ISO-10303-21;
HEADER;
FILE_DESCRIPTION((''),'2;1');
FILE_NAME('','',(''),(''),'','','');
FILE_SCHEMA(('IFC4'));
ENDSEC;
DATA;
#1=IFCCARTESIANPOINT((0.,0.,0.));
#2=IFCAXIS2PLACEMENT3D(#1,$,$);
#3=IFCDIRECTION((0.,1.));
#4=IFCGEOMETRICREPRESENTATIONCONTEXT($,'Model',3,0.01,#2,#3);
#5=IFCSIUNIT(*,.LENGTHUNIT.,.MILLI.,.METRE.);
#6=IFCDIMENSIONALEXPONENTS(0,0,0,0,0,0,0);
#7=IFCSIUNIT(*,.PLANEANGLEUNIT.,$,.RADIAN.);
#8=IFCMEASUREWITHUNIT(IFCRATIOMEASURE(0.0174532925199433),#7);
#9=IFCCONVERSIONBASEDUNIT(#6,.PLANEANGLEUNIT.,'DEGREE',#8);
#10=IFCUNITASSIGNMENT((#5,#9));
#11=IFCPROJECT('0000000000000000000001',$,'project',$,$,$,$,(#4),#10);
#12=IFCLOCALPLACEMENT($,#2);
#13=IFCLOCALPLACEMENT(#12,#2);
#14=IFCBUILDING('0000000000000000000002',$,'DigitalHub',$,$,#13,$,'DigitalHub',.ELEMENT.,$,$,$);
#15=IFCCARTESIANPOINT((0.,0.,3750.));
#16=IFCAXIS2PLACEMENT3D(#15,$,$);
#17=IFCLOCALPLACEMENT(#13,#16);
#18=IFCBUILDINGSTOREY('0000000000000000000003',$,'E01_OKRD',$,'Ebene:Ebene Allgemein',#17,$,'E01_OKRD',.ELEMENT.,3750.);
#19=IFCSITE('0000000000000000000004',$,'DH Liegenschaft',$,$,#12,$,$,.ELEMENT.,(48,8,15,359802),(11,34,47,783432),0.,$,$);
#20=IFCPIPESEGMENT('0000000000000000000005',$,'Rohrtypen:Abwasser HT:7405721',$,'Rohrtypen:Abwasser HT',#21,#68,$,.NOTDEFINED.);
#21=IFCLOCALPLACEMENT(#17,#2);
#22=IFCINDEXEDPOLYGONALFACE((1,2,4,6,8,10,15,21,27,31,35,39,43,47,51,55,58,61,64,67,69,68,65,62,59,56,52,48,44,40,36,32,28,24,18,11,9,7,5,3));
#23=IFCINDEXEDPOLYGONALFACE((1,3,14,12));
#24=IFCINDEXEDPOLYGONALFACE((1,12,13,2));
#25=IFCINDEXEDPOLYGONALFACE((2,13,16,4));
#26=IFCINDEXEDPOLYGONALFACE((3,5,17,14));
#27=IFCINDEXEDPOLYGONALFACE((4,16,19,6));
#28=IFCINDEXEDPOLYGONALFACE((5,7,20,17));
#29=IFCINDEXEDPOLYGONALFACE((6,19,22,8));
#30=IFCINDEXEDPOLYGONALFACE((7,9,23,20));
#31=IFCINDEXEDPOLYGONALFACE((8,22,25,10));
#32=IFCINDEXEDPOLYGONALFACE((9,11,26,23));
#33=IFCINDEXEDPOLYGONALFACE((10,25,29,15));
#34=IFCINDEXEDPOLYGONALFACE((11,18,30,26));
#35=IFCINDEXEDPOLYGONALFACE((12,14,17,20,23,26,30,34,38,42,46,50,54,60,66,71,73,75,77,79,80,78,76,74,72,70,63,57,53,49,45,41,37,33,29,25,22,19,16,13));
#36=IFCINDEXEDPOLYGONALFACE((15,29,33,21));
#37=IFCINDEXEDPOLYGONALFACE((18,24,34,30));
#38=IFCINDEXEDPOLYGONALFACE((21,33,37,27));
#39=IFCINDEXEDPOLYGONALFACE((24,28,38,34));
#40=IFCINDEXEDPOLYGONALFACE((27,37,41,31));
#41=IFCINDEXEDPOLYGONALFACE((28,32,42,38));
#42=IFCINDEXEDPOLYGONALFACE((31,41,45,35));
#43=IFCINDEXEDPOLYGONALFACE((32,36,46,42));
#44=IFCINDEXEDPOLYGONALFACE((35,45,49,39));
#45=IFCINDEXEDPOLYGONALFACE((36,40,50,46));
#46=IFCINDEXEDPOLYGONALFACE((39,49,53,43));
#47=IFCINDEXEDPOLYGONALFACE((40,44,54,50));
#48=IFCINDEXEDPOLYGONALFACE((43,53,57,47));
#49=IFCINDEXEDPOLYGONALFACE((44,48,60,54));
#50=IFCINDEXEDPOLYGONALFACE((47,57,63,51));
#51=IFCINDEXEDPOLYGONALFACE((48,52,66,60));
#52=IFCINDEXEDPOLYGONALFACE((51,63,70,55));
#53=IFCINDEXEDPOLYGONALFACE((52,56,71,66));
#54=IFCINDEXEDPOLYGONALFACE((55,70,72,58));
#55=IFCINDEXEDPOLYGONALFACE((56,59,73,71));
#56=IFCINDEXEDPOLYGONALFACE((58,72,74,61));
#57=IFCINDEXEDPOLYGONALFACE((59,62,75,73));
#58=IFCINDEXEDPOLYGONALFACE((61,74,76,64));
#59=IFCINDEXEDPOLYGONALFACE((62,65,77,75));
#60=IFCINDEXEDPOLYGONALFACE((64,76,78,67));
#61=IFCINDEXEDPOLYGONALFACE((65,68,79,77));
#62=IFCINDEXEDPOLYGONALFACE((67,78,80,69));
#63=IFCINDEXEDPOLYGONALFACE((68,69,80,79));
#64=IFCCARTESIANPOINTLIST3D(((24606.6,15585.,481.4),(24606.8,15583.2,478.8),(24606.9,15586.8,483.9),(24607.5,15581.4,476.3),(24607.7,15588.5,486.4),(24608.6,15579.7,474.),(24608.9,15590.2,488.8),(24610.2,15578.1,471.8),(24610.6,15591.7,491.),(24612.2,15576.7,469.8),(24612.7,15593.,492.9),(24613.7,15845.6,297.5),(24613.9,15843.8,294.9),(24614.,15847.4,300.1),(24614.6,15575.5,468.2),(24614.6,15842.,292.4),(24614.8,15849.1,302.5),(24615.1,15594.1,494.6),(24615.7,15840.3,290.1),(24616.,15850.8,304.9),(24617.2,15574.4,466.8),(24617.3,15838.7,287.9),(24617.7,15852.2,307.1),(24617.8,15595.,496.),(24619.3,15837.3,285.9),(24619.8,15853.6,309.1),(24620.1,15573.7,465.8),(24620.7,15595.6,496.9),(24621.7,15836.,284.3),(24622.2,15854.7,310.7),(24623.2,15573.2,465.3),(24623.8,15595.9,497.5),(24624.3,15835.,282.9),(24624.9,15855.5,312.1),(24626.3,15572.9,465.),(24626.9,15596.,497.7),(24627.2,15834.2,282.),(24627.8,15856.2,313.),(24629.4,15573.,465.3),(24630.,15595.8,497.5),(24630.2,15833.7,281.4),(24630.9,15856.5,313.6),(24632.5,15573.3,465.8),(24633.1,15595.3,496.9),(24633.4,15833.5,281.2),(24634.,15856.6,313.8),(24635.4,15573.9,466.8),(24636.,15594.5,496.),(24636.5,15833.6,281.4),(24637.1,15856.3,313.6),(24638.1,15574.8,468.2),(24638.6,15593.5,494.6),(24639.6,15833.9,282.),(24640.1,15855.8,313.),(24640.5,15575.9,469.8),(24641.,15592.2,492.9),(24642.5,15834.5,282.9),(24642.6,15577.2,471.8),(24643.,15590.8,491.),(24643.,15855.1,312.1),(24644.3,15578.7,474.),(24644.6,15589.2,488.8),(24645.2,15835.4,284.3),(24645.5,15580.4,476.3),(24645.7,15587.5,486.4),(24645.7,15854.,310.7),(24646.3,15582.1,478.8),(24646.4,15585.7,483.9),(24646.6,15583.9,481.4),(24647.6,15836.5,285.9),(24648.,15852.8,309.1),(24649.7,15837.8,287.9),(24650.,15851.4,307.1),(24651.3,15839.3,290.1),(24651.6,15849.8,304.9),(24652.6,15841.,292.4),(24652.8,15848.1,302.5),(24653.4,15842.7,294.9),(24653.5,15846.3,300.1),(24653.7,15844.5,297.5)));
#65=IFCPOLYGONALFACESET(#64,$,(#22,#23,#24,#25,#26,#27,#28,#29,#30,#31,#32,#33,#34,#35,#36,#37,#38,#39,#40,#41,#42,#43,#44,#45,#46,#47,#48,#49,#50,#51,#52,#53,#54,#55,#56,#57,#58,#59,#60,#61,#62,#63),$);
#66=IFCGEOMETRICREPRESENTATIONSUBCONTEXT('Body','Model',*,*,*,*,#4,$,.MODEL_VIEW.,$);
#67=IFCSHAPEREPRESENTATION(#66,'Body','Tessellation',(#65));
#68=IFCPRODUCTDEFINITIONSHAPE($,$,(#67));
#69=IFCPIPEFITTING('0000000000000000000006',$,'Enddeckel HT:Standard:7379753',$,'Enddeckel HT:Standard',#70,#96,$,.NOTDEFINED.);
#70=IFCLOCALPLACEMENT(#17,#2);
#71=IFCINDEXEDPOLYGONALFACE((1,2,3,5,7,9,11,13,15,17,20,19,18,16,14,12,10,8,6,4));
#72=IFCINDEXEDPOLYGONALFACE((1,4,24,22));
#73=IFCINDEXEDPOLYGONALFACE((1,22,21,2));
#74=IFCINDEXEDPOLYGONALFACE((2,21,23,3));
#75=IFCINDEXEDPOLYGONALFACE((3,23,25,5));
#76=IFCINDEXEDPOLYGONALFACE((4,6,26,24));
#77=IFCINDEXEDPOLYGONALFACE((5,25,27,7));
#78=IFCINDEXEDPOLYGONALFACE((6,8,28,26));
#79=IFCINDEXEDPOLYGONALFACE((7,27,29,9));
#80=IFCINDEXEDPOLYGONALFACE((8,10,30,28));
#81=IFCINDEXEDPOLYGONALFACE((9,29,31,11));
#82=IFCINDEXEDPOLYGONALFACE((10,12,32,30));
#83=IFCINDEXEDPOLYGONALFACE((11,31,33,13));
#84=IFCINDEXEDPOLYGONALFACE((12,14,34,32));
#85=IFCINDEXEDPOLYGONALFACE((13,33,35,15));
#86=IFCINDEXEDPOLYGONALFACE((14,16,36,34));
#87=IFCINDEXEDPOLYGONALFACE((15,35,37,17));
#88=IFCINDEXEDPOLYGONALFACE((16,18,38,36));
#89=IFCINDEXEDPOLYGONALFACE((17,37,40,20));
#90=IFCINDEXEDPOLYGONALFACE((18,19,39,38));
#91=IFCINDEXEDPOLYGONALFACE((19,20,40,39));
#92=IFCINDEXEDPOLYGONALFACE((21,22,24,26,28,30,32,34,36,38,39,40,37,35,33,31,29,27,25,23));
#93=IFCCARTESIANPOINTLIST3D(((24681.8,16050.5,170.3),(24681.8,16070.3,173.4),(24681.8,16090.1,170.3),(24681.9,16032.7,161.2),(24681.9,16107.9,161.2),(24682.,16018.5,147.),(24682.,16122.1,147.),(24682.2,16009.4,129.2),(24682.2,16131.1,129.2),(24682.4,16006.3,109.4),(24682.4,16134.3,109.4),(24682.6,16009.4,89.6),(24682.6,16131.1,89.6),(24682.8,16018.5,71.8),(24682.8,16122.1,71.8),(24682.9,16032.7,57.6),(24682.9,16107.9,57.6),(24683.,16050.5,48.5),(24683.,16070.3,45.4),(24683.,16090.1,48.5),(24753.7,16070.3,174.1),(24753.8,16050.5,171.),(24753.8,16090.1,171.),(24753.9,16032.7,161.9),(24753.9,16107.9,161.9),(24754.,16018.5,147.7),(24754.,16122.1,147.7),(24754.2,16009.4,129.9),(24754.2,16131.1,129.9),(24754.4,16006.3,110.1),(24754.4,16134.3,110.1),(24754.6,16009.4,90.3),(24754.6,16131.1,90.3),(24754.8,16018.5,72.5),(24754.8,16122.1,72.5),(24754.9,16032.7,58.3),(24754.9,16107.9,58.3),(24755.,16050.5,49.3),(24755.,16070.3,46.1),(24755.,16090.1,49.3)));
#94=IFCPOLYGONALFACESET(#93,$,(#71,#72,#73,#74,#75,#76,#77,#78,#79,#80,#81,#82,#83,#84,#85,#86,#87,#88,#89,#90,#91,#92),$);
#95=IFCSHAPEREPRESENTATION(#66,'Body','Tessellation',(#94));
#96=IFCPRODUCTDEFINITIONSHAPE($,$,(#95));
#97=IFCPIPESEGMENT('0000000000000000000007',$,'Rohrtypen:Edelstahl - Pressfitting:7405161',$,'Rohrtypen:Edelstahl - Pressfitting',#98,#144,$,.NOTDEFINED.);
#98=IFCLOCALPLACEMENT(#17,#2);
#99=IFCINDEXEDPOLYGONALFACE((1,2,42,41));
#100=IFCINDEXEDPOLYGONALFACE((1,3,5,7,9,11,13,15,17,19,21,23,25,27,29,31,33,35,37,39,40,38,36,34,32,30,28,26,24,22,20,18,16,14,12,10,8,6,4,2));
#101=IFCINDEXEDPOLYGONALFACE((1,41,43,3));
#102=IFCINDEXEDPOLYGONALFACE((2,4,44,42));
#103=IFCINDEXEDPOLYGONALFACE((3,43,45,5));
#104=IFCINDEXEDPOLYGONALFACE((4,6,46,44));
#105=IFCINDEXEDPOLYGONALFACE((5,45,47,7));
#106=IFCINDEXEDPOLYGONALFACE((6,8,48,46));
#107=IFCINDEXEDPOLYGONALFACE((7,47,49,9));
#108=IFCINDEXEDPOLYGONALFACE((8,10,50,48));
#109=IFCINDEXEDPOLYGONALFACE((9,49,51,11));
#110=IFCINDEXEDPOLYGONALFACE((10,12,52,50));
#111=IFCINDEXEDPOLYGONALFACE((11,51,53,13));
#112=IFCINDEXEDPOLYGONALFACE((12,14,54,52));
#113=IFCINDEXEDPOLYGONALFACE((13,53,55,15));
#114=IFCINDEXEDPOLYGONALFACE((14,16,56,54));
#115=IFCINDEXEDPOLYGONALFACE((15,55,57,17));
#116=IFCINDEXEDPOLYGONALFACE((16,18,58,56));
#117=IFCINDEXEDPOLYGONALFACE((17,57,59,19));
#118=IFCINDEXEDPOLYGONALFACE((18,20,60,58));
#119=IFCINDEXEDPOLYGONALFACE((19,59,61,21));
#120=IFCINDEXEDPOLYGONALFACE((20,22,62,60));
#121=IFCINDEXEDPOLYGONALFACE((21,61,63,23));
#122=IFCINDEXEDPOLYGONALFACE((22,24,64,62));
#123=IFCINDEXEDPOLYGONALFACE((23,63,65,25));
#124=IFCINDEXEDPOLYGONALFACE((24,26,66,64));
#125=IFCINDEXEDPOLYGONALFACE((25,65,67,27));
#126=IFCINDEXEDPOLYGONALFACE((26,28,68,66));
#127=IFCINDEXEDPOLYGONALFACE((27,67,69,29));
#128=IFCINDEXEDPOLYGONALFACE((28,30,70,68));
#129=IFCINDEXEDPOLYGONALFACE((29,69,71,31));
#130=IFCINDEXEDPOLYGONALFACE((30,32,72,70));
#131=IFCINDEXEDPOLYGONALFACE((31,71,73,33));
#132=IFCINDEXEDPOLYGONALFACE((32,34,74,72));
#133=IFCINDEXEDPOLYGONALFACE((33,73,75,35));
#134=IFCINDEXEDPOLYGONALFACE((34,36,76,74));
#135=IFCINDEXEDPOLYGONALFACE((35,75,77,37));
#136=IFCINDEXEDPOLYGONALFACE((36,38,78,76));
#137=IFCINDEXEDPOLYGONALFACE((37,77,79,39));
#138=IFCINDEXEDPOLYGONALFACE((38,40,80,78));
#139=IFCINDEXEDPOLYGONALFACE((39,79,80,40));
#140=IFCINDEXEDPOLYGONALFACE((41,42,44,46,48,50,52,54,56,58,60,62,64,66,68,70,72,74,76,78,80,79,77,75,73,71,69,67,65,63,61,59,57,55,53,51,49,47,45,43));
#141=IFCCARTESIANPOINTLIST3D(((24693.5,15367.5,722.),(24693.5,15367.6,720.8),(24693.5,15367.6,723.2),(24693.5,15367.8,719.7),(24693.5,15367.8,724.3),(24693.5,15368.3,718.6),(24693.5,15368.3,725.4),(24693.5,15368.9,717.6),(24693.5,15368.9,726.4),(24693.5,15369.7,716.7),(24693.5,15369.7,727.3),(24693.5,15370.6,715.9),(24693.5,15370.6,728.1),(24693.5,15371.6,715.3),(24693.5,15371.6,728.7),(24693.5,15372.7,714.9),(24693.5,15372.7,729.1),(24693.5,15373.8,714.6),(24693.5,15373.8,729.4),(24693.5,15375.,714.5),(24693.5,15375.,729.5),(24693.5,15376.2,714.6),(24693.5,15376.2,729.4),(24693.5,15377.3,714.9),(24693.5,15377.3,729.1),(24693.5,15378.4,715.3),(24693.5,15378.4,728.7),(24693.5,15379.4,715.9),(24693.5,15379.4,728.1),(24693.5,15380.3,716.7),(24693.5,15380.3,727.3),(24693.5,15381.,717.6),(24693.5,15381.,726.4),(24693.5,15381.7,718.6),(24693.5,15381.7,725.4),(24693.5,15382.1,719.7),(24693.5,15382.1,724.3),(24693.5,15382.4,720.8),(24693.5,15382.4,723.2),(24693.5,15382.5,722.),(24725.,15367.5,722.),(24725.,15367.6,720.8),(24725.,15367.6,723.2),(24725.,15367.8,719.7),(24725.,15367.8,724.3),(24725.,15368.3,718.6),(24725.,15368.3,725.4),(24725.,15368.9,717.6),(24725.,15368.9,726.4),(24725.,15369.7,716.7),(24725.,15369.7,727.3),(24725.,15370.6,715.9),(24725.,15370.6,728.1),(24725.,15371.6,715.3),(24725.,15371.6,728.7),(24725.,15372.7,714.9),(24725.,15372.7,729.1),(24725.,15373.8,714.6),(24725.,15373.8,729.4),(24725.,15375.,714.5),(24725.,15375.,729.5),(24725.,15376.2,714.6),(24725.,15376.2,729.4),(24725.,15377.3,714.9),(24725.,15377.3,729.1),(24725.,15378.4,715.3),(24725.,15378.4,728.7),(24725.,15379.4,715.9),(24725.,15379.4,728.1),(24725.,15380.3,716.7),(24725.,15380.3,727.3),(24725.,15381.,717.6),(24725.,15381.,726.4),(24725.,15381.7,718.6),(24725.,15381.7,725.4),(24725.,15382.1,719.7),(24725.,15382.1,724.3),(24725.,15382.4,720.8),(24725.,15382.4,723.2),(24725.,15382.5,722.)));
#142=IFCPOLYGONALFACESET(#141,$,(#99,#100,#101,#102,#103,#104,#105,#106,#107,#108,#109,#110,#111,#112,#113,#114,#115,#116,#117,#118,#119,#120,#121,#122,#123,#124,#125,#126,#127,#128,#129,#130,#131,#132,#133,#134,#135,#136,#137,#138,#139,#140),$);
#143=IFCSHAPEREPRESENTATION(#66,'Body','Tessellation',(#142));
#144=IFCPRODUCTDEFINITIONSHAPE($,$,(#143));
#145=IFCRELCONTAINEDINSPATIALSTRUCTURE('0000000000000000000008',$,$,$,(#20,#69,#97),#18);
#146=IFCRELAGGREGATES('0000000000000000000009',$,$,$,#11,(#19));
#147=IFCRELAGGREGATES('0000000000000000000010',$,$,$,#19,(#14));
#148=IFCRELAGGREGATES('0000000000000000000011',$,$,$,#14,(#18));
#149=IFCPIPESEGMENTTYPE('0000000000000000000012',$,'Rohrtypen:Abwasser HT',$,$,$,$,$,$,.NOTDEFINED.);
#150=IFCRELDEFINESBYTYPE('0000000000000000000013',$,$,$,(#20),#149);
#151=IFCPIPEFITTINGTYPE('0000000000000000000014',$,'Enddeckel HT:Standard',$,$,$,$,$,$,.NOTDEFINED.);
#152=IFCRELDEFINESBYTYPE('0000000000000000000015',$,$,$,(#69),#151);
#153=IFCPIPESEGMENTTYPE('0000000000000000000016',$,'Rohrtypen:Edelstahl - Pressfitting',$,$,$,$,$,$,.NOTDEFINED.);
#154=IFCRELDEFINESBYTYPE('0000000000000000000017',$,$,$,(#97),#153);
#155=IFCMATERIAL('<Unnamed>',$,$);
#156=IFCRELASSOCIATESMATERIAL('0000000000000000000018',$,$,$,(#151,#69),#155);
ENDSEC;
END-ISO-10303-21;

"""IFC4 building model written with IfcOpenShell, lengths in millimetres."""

from ifc_helpers import new_model, entity, si_unit, converted_unit, direction, frame, origin, place, context, subcontext, project, spatial, indexed_curve, outline, extrude, source, transform, mapped, material, type_object, type_shapes, element, save


model = new_model("IFC4")

# Units and contexts
model_context = context("Model", 3, precision=0.01, world=origin(), true_north=direction((0.0, 1.0)))
body_context = subcontext(model_context, "Body", "Model", "MODEL_VIEW")
ifc_project = project(units=[si_unit("LENGTHUNIT", "METRE", prefix="MILLI"), converted_unit("PLANEANGLEUNIT", "DEGREE", entity("IfcRatioMeasure", 0.0174532925199433), si_unit("PLANEANGLEUNIT", "RADIAN"), dimensions=[0, 0, 0, 0, 0, 0, 0])], contexts=[model_context])

# Site, building, storey
site_placement = place(None, origin())
site = spatial("IfcSite", under=ifc_project, at=site_placement, Name="DH Liegenschaft", CompositionType="ELEMENT", RefLatitude=(48, 8, 15, 359802), RefLongitude=(11, 34, 47, 783432), RefElevation=0.0)
building_placement = place(site_placement, origin())
building = spatial("IfcBuilding", under=site, at=building_placement, Name="DigitalHub", LongName="DigitalHub", CompositionType="ELEMENT")
storey_placement = place(building_placement, frame((0.0, 0.0, 3750.0)))
storey = spatial("IfcBuildingStorey", under=building, at=storey_placement, Name="E01_OKRD", ObjectType="Ebene:Ebene Allgemein", LongName="E01_OKRD", CompositionType="ELEMENT", Elevation=3750.0)

# Pipe segment
pipe_segment_type_1 = type_object("IfcPipeSegmentType", Name="Rohrtypen:Abwasser HT", PredefinedType="NOTDEFINED")
pipe_segment_1_placement = place(storey_placement, frame((24605.0, 15571.3, 279.6)))
element("IfcPipeSegment", 1, at=pipe_segment_1_placement, inside=storey, type_object=pipe_segment_type_1, Name="Rohrtypen:Abwasser HT:7405721", ObjectType="Rohrtypen:Abwasser HT", PredefinedType="NOTDEFINED", context=body_context, shape_type="SweptSolid", body=[
    extrude(outline(indexed_curve([(20.0, 0.0), (19.8, 3.1), (19.0, 6.2), (17.8, 9.1), (16.2, 11.8), (14.1, 14.1), (11.8, 16.2), (9.1, 17.8), (6.2, 19.0), (3.1, 19.8), (0.0, 20.0), (-3.1, 19.8), (-6.2, 19.0), (-9.1, 17.8), (-11.8, 16.2), (-14.1, 14.1), (-16.2, 11.8), (-17.8, 9.1), (-19.0, 6.2), (-19.8, 3.1), (-20.0, 0.0), (-19.8, -3.1), (-19.0, -6.2), (-17.8, -9.1), (-16.2, -11.8), (-14.1, -14.1), (-11.8, -16.2), (-9.1, -17.8), (-6.2, -19.0), (-3.1, -19.8), (0.0, -20.0), (3.1, -19.8), (6.2, -19.0), (9.1, -17.8), (11.8, -16.2), (14.1, -14.1), (16.2, -11.8), (17.8, -9.1), (19.0, -6.2), (19.8, -3.1), (20.0, 0.0)], self_intersect=False)), frame((21.6, 13.1, 201.8), z_axis=(0.022177, 0.81683, -0.576452), x_axis=(-0.999632, 0.027141, 0.0)), (0.0, 0.0, 1.0), 319.0),
])

# Pipe fitting
ifc_material = material(Name="<Unnamed>")
pipe_fitting_type = type_object("IfcPipeFittingType", Name="Enddeckel HT:Standard", PredefinedType="NOTDEFINED", material=ifc_material)
shared_shape = source(origin(), body_context, "Body", "SweptSolid", [
    extrude(outline(indexed_curve([(64.0, 0.0), (60.9, 19.8), (51.8, 37.6), (37.6, 51.8), (19.8, 60.9), (0.0, 64.0), (-19.8, 60.9), (-37.6, 51.8), (-51.8, 37.6), (-60.9, 19.8), (-64.0, 0.0), (-60.9, -19.8), (-51.8, -37.6), (-37.6, -51.8), (-19.8, -60.9), (0.0, -64.0), (19.8, -60.9), (37.6, -51.8), (51.8, -37.6), (60.9, -19.8), (64.0, 0.0)], self_intersect=False)), frame((0.0, 0.0, 0.0), z_axis=(1.0, 0.0, 0.0), x_axis=(0.0, 1.0, 0.0)), (0.0, 0.0, 1.0), 72.0),
])
type_shapes(pipe_fitting_type, [shared_shape])
pipe_fitting_placement = place(storey_placement, frame((24682.4, 16070.3, 109.4), z_axis=(-0.01, 0.0, 0.99995), x_axis=(0.99995, 0.0, 0.01)))
element("IfcPipeFitting", 2, at=pipe_fitting_placement, inside=storey, type_object=pipe_fitting_type, material=ifc_material, Name="Enddeckel HT:Standard:7379753", ObjectType="Enddeckel HT:Standard", PredefinedType="NOTDEFINED", context=body_context, shape_type="MappedRepresentation", body=[
    mapped(shared_shape, transform((0.0, 0.0, 0.0), scale=1.0)),
])

# Pipe segment
pipe_segment_type_2 = type_object("IfcPipeSegmentType", Name="Rohrtypen:Edelstahl - Pressfitting", PredefinedType="NOTDEFINED")
pipe_segment_2_placement = place(storey_placement, frame((24693.5, 15365.9, 712.9)))
element("IfcPipeSegment", 3, at=pipe_segment_2_placement, inside=storey, type_object=pipe_segment_type_2, Name="Rohrtypen:Edelstahl - Pressfitting:7405161", ObjectType="Rohrtypen:Edelstahl - Pressfitting", PredefinedType="NOTDEFINED", context=body_context, shape_type="SweptSolid", body=[
    extrude(outline(indexed_curve([(7.5, 0.0), (7.4, 1.2), (7.1, 2.3), (6.7, 3.4), (6.1, 4.4), (5.3, 5.3), (4.4, 6.1), (3.4, 6.7), (2.3, 7.1), (1.2, 7.4), (0.0, 7.5), (-1.2, 7.4), (-2.3, 7.1), (-3.4, 6.7), (-4.4, 6.1), (-5.3, 5.3), (-6.1, 4.4), (-6.7, 3.4), (-7.1, 2.3), (-7.4, 1.2), (-7.5, 0.0), (-7.4, -1.2), (-7.1, -2.3), (-6.7, -3.4), (-6.1, -4.4), (-5.3, -5.3), (-4.4, -6.1), (-3.4, -6.7), (-2.3, -7.1), (-1.2, -7.4), (0.0, -7.5), (1.2, -7.4), (2.3, -7.1), (3.4, -6.7), (4.4, -6.1), (5.3, -5.3), (6.1, -4.4), (6.7, -3.4), (7.1, -2.3), (7.4, -1.2), (7.5, 0.0)], self_intersect=False)), frame((0.0, 9.1, 9.1), z_axis=(1.0, 0.0, 0.0), x_axis=(0.0, 1.0, 0.0)), (0.0, 0.0, 1.0), 31.5),
])

save(model, "model.ifc")
